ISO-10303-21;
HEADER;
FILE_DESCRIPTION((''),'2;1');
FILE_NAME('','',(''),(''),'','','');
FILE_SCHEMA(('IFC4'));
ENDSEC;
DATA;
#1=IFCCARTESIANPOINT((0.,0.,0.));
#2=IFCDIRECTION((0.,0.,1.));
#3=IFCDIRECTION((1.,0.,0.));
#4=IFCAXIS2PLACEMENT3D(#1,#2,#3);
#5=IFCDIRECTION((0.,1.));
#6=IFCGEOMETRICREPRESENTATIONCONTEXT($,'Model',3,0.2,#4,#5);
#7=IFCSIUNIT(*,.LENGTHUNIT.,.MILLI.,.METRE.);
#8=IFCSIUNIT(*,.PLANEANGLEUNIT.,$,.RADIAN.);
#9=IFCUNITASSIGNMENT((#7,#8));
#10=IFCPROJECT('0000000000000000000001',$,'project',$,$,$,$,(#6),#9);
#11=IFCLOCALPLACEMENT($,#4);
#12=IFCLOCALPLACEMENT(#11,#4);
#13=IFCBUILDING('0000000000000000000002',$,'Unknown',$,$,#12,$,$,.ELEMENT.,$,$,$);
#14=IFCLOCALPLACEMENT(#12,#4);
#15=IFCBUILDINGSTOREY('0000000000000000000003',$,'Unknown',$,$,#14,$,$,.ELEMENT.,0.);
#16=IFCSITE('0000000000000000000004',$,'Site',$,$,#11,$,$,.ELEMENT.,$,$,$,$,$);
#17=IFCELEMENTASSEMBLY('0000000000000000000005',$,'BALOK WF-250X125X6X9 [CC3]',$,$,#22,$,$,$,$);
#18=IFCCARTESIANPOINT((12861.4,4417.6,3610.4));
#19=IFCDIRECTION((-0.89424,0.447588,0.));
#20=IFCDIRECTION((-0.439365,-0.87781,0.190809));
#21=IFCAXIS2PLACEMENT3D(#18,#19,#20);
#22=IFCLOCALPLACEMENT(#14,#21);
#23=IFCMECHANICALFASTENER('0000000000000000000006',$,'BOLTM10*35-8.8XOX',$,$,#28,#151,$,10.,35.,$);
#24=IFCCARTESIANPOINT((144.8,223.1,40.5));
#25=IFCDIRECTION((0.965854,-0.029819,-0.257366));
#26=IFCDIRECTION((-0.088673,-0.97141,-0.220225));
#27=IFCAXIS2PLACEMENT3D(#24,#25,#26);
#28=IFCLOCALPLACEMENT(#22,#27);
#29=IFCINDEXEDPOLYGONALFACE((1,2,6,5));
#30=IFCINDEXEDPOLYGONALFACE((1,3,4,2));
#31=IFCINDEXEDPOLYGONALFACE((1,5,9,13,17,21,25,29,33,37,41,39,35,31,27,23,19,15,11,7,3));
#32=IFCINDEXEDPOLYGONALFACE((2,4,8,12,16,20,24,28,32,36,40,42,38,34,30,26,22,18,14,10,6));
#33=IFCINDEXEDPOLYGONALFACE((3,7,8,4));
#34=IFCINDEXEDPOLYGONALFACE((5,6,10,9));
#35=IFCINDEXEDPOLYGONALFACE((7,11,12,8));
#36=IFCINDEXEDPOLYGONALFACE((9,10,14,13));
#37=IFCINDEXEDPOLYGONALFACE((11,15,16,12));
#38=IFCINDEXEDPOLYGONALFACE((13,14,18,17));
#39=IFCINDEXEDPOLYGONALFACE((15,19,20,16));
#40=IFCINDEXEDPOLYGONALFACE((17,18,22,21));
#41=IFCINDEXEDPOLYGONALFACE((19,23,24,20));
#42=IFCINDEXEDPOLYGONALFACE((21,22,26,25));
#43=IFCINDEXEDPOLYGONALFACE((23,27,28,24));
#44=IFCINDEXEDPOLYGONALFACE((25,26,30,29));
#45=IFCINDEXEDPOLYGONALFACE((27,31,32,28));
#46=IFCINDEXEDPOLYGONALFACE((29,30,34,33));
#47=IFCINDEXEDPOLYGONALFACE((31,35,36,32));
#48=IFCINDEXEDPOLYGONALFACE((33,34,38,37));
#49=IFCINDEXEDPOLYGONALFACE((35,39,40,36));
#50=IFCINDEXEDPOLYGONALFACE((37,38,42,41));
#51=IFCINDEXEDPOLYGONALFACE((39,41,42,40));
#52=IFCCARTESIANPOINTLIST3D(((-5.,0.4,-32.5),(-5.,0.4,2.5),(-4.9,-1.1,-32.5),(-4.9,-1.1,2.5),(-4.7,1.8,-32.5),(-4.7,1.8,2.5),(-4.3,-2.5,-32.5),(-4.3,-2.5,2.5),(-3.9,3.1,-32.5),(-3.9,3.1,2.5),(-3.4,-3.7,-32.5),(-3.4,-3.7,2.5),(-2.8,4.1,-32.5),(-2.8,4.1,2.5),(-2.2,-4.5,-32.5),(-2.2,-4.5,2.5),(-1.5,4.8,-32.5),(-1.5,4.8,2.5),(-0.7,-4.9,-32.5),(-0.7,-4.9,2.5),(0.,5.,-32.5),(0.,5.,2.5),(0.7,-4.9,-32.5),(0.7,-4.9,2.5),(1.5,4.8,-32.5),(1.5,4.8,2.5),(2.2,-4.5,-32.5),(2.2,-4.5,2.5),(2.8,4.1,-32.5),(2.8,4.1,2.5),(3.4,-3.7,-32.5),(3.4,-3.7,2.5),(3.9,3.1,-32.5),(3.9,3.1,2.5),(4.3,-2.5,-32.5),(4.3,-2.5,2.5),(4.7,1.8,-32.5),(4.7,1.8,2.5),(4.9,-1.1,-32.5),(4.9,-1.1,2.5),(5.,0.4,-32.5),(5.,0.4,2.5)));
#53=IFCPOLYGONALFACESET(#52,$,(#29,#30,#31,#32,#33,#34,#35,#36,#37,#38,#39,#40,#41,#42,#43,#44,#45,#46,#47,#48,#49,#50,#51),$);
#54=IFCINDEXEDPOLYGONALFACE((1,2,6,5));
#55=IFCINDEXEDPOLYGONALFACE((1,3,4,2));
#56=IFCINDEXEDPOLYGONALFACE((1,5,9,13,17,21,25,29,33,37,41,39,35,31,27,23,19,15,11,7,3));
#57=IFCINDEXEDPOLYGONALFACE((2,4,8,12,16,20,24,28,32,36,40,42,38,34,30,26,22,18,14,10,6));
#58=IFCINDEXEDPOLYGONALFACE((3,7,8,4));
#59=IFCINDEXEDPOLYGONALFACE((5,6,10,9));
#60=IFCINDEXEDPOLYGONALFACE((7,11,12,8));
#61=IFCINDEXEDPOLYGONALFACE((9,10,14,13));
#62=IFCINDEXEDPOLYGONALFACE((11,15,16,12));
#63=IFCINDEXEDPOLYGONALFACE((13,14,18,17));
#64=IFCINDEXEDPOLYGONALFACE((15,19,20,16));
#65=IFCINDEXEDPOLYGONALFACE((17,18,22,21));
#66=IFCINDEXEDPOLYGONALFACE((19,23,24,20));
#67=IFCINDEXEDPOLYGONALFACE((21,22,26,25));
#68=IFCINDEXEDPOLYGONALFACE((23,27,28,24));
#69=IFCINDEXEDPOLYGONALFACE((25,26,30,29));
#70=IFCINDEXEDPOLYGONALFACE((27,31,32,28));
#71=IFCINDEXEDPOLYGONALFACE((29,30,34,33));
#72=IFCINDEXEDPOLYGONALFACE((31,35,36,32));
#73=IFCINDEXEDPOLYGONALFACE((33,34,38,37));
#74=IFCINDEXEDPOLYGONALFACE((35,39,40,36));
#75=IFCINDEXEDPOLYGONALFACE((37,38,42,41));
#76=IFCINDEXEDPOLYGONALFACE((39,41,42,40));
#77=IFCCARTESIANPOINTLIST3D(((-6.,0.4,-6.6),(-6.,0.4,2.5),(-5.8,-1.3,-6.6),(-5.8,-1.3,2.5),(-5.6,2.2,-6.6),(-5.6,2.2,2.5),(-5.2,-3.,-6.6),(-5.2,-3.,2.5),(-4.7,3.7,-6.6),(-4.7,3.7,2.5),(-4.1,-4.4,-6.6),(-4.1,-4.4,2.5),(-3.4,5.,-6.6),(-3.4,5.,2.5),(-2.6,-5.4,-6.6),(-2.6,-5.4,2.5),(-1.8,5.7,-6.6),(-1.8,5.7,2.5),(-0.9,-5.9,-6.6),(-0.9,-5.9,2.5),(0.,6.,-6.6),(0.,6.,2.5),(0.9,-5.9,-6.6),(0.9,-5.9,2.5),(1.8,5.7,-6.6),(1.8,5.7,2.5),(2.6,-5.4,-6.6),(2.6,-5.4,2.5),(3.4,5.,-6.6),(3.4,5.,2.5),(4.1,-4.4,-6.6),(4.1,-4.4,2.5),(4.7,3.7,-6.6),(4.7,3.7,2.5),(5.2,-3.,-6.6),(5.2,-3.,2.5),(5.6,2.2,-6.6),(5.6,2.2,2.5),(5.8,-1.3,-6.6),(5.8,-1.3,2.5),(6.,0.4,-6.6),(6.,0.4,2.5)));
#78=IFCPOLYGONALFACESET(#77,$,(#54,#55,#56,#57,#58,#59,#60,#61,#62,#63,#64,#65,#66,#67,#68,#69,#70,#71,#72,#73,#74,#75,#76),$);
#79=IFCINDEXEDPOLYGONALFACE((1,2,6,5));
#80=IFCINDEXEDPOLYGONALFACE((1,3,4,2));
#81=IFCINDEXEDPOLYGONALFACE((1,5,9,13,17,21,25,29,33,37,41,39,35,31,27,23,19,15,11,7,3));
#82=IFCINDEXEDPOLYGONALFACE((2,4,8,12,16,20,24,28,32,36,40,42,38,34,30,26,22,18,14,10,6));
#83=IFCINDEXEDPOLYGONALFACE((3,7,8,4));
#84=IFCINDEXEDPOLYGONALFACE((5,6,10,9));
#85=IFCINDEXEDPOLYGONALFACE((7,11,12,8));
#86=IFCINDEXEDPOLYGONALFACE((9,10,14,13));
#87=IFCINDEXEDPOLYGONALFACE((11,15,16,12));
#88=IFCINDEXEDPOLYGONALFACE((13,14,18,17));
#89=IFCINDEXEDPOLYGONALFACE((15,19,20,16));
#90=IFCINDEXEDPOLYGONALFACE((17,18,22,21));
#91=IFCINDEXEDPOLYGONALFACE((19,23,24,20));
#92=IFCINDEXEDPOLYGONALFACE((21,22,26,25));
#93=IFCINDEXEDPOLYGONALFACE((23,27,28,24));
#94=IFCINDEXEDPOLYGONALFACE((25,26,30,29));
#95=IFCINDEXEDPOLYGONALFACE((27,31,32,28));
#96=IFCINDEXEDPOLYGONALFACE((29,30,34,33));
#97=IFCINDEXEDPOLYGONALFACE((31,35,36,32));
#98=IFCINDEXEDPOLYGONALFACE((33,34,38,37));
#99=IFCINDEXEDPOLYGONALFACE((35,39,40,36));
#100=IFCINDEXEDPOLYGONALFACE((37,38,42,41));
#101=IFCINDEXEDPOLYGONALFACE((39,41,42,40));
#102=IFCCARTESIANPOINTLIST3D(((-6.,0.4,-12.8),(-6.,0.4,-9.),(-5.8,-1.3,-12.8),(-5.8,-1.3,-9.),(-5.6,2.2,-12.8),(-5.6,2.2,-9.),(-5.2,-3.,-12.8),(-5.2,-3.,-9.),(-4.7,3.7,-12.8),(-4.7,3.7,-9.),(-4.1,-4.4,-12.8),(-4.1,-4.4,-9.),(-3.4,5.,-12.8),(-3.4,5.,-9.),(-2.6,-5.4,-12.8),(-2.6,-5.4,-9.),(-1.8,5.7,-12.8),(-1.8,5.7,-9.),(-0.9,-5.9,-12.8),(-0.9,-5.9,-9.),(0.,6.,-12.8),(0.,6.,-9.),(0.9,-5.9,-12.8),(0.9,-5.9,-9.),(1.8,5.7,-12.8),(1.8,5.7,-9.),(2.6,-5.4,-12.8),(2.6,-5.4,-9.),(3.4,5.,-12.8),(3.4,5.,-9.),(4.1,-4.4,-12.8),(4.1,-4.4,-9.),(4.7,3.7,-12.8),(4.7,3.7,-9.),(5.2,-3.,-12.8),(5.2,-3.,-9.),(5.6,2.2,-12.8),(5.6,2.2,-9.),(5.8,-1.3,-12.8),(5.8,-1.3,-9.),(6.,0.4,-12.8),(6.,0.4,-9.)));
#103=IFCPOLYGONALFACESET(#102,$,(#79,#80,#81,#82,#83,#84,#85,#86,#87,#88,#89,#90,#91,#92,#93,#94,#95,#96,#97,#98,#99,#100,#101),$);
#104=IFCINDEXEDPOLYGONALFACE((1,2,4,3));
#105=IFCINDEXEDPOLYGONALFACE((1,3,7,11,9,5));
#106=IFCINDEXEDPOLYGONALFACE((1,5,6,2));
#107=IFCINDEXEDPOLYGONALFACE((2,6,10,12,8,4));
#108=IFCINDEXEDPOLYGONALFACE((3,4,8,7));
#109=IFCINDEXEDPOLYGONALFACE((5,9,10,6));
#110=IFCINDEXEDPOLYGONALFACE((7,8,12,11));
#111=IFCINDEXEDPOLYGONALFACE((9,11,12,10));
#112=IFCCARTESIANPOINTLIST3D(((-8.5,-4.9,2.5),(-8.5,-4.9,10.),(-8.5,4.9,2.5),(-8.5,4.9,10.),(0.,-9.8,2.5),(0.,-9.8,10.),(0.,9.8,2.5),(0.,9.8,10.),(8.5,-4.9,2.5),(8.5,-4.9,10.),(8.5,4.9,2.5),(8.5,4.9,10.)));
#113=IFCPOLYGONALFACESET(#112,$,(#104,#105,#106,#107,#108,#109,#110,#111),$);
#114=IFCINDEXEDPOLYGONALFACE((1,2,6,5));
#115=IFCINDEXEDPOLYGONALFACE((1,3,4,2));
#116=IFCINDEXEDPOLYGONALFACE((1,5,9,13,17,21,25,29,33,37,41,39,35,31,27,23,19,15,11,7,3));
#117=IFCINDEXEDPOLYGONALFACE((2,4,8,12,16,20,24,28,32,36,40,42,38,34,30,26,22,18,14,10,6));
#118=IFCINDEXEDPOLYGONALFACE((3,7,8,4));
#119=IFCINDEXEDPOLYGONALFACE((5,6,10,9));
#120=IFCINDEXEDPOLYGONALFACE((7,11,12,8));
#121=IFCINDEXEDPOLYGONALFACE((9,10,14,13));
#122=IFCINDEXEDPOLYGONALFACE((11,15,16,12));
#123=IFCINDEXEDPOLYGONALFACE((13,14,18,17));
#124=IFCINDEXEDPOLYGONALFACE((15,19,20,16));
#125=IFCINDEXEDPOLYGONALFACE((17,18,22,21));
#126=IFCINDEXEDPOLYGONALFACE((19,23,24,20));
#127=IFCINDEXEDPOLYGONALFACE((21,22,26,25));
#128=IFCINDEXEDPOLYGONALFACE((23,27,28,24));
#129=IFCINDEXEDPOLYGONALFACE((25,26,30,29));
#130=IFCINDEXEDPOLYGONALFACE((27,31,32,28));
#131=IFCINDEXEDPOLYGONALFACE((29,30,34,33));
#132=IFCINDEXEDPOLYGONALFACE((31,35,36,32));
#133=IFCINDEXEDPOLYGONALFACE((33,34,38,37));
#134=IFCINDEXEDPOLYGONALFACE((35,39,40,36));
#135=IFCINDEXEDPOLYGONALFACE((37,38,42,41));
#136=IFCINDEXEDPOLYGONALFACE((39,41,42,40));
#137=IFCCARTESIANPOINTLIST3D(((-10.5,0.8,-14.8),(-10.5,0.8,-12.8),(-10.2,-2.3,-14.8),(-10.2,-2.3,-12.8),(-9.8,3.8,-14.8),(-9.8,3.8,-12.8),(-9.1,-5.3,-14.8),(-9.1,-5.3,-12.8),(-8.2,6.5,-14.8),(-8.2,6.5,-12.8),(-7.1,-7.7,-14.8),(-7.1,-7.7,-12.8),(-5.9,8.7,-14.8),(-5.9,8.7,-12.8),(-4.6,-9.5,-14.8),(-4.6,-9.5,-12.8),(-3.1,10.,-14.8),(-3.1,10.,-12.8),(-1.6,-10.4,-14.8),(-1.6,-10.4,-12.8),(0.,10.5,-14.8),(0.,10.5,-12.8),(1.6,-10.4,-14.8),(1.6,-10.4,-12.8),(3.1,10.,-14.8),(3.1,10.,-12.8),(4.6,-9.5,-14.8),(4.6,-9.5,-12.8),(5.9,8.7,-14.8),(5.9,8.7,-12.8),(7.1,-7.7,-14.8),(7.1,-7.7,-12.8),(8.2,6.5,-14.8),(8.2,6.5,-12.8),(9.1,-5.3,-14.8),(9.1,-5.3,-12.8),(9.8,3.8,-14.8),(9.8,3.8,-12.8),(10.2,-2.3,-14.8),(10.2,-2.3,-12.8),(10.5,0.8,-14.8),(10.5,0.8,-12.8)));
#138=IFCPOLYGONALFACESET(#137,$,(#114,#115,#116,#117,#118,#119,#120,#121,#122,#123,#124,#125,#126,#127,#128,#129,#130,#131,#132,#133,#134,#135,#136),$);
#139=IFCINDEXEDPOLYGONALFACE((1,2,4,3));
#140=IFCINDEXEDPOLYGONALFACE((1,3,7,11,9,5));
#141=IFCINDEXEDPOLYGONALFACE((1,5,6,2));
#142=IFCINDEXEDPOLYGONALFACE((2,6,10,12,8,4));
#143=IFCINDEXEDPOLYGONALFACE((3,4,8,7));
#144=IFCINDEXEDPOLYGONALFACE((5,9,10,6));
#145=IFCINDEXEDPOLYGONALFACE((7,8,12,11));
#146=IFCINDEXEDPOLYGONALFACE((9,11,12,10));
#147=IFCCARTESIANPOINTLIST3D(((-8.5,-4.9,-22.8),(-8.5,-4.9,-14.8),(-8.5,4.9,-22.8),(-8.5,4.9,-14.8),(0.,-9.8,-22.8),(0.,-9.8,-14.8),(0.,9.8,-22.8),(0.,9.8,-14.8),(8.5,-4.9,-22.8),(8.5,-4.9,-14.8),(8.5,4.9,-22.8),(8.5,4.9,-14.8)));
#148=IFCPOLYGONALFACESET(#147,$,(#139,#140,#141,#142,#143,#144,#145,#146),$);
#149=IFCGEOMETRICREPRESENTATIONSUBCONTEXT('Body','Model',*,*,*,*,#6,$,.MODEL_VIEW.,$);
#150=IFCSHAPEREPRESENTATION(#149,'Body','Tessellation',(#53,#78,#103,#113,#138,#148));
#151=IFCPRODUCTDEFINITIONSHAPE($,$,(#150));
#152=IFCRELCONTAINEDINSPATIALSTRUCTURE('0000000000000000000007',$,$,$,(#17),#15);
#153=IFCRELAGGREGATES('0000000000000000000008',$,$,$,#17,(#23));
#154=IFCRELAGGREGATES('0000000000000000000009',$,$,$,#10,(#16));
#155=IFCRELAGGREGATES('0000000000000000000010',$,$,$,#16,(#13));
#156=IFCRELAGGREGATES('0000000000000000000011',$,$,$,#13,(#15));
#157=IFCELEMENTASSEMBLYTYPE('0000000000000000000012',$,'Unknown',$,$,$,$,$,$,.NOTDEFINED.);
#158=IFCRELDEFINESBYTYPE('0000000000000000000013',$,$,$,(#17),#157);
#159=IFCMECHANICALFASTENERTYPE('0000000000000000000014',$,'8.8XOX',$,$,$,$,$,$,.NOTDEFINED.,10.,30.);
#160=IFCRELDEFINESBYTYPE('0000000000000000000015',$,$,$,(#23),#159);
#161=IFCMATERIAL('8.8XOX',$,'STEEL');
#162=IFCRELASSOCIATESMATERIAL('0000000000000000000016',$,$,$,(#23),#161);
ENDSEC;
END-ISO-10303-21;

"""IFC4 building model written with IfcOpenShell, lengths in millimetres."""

from ifc_helpers import new_model, si_unit, direction, frame, origin_with_axes, origin_2d_with_axis, place, context, subcontext, project, spatial, polyline, circle, outline, extrude, source, transform, mapped, material, type_object, element, aggregate, save


model = new_model("IFC4")

# Units and contexts
model_context = context("Model", 3, precision=0.2, world=origin_with_axes(), true_north=direction((0.0, 1.0)))
body_context = subcontext(model_context, "Body", "Model", "MODEL_VIEW")
ifc_project = project(units=[si_unit("LENGTHUNIT", "METRE", prefix="MILLI"), si_unit("PLANEANGLEUNIT", "RADIAN")], contexts=[model_context])

# Site, building, storey
site_placement = place(None, origin_with_axes())
site = spatial("IfcSite", under=ifc_project, at=site_placement, Name="Site", CompositionType="ELEMENT")
building_placement = place(site_placement, origin_with_axes())
building = spatial("IfcBuilding", under=site, at=building_placement, Name="Unknown", CompositionType="ELEMENT")
storey_placement = place(building_placement, origin_with_axes())
storey = spatial("IfcBuildingStorey", under=building, at=storey_placement, Name="Unknown", CompositionType="ELEMENT", Elevation=0.0)

# Element assembly
element_assembly_type = type_object("IfcElementAssemblyType", Name="Unknown", PredefinedType="NOTDEFINED")
assembly_1_placement = place(storey_placement, frame((12861.4, 4417.6, 3610.4), z_axis=(-0.89424, 0.447588, 0.0), x_axis=(-0.439365, -0.87781, 0.190809)))
assembly_1 = element("IfcElementAssembly", 1, at=assembly_1_placement, inside=storey, type_object=element_assembly_type, Name="BALOK WF-250X125X6X9 [CC3]")

# Mechanical fastener
ifc_material_1 = material(Name="8.8XOX", Category="STEEL")
mechanical_fastener_type_1 = type_object("IfcMechanicalFastenerType", Name="8.8XOX", NominalDiameter=10.0, NominalLength=30.0, PredefinedType="NOTDEFINED")
shared_shape_1 = source(origin_with_axes(), body_context, "Body", "SweptSolid", [
    extrude(circle(Radius=5.0, at=origin_2d_with_axis()), frame((0.0, 0.0, 2.5), z_axis=(0.0, 0.0, -1.0), x_axis=(0.0, 1.0, 0.0)), (0.0, 0.0, 1.0), 35.0),
    extrude(circle(Radius=6.0, at=origin_2d_with_axis()), frame((0.0, 0.0, 2.5), z_axis=(0.0, 0.0, -1.0), x_axis=(0.0, 1.0, 0.0)), (0.0, 0.0, 1.0), 9.1),
    extrude(circle(Radius=6.0, at=origin_2d_with_axis()), frame((0.0, 0.0, -9.0), z_axis=(0.0, 0.0, -1.0), x_axis=(0.0, 1.0, 0.0)), (0.0, 0.0, 1.0), 3.8),
    extrude(outline(polyline([(9.8, 0.0), (4.9, 8.5), (-4.9, 8.5), (-9.8, 0.0), (-4.9, -8.5), (4.9, -8.5), (9.8, 0.0)])), frame((0.0, 0.0, 10.0), z_axis=(0.0, 0.0, -1.0), x_axis=(0.0, 1.0, 0.0)), (0.0, 0.0, 1.0), 7.5),
    extrude(circle(Radius=10.5, at=origin_2d_with_axis()), frame((0.0, 0.0, -12.8), z_axis=(0.0, 0.0, -1.0), x_axis=(0.0, 1.0, 0.0)), (0.0, 0.0, 1.0), 2.0),
    extrude(outline(polyline([(9.8, 0.0), (4.9, 8.5), (-4.9, 8.5), (-9.8, 0.0), (-4.9, -8.5), (4.9, -8.5), (9.8, 0.0)])), frame((0.0, 0.0, -14.8), z_axis=(0.0, 0.0, -1.0), x_axis=(0.0, 1.0, 0.0)), (0.0, 0.0, 1.0), 8.0),
])
mechanical_fastener_1_placement = place(assembly_1_placement, frame((144.8, 223.1, 40.5), z_axis=(0.965854, -0.029819, -0.257366), x_axis=(-0.088673, -0.97141, -0.220225)))
mechanical_fastener_1 = element("IfcMechanicalFastener", 2, at=mechanical_fastener_1_placement, type_object=mechanical_fastener_type_1, material=ifc_material_1, Name="BOLTM10*35-8.8XOX", NominalDiameter=10.0, NominalLength=35.0, context=body_context, shape_type="MappedRepresentation", body=[
    mapped(shared_shape_1, transform((0.0, 0.0, 0.0))),
])
aggregate(assembly_1, [mechanical_fastener_1])

save(model, "model.ifc")
